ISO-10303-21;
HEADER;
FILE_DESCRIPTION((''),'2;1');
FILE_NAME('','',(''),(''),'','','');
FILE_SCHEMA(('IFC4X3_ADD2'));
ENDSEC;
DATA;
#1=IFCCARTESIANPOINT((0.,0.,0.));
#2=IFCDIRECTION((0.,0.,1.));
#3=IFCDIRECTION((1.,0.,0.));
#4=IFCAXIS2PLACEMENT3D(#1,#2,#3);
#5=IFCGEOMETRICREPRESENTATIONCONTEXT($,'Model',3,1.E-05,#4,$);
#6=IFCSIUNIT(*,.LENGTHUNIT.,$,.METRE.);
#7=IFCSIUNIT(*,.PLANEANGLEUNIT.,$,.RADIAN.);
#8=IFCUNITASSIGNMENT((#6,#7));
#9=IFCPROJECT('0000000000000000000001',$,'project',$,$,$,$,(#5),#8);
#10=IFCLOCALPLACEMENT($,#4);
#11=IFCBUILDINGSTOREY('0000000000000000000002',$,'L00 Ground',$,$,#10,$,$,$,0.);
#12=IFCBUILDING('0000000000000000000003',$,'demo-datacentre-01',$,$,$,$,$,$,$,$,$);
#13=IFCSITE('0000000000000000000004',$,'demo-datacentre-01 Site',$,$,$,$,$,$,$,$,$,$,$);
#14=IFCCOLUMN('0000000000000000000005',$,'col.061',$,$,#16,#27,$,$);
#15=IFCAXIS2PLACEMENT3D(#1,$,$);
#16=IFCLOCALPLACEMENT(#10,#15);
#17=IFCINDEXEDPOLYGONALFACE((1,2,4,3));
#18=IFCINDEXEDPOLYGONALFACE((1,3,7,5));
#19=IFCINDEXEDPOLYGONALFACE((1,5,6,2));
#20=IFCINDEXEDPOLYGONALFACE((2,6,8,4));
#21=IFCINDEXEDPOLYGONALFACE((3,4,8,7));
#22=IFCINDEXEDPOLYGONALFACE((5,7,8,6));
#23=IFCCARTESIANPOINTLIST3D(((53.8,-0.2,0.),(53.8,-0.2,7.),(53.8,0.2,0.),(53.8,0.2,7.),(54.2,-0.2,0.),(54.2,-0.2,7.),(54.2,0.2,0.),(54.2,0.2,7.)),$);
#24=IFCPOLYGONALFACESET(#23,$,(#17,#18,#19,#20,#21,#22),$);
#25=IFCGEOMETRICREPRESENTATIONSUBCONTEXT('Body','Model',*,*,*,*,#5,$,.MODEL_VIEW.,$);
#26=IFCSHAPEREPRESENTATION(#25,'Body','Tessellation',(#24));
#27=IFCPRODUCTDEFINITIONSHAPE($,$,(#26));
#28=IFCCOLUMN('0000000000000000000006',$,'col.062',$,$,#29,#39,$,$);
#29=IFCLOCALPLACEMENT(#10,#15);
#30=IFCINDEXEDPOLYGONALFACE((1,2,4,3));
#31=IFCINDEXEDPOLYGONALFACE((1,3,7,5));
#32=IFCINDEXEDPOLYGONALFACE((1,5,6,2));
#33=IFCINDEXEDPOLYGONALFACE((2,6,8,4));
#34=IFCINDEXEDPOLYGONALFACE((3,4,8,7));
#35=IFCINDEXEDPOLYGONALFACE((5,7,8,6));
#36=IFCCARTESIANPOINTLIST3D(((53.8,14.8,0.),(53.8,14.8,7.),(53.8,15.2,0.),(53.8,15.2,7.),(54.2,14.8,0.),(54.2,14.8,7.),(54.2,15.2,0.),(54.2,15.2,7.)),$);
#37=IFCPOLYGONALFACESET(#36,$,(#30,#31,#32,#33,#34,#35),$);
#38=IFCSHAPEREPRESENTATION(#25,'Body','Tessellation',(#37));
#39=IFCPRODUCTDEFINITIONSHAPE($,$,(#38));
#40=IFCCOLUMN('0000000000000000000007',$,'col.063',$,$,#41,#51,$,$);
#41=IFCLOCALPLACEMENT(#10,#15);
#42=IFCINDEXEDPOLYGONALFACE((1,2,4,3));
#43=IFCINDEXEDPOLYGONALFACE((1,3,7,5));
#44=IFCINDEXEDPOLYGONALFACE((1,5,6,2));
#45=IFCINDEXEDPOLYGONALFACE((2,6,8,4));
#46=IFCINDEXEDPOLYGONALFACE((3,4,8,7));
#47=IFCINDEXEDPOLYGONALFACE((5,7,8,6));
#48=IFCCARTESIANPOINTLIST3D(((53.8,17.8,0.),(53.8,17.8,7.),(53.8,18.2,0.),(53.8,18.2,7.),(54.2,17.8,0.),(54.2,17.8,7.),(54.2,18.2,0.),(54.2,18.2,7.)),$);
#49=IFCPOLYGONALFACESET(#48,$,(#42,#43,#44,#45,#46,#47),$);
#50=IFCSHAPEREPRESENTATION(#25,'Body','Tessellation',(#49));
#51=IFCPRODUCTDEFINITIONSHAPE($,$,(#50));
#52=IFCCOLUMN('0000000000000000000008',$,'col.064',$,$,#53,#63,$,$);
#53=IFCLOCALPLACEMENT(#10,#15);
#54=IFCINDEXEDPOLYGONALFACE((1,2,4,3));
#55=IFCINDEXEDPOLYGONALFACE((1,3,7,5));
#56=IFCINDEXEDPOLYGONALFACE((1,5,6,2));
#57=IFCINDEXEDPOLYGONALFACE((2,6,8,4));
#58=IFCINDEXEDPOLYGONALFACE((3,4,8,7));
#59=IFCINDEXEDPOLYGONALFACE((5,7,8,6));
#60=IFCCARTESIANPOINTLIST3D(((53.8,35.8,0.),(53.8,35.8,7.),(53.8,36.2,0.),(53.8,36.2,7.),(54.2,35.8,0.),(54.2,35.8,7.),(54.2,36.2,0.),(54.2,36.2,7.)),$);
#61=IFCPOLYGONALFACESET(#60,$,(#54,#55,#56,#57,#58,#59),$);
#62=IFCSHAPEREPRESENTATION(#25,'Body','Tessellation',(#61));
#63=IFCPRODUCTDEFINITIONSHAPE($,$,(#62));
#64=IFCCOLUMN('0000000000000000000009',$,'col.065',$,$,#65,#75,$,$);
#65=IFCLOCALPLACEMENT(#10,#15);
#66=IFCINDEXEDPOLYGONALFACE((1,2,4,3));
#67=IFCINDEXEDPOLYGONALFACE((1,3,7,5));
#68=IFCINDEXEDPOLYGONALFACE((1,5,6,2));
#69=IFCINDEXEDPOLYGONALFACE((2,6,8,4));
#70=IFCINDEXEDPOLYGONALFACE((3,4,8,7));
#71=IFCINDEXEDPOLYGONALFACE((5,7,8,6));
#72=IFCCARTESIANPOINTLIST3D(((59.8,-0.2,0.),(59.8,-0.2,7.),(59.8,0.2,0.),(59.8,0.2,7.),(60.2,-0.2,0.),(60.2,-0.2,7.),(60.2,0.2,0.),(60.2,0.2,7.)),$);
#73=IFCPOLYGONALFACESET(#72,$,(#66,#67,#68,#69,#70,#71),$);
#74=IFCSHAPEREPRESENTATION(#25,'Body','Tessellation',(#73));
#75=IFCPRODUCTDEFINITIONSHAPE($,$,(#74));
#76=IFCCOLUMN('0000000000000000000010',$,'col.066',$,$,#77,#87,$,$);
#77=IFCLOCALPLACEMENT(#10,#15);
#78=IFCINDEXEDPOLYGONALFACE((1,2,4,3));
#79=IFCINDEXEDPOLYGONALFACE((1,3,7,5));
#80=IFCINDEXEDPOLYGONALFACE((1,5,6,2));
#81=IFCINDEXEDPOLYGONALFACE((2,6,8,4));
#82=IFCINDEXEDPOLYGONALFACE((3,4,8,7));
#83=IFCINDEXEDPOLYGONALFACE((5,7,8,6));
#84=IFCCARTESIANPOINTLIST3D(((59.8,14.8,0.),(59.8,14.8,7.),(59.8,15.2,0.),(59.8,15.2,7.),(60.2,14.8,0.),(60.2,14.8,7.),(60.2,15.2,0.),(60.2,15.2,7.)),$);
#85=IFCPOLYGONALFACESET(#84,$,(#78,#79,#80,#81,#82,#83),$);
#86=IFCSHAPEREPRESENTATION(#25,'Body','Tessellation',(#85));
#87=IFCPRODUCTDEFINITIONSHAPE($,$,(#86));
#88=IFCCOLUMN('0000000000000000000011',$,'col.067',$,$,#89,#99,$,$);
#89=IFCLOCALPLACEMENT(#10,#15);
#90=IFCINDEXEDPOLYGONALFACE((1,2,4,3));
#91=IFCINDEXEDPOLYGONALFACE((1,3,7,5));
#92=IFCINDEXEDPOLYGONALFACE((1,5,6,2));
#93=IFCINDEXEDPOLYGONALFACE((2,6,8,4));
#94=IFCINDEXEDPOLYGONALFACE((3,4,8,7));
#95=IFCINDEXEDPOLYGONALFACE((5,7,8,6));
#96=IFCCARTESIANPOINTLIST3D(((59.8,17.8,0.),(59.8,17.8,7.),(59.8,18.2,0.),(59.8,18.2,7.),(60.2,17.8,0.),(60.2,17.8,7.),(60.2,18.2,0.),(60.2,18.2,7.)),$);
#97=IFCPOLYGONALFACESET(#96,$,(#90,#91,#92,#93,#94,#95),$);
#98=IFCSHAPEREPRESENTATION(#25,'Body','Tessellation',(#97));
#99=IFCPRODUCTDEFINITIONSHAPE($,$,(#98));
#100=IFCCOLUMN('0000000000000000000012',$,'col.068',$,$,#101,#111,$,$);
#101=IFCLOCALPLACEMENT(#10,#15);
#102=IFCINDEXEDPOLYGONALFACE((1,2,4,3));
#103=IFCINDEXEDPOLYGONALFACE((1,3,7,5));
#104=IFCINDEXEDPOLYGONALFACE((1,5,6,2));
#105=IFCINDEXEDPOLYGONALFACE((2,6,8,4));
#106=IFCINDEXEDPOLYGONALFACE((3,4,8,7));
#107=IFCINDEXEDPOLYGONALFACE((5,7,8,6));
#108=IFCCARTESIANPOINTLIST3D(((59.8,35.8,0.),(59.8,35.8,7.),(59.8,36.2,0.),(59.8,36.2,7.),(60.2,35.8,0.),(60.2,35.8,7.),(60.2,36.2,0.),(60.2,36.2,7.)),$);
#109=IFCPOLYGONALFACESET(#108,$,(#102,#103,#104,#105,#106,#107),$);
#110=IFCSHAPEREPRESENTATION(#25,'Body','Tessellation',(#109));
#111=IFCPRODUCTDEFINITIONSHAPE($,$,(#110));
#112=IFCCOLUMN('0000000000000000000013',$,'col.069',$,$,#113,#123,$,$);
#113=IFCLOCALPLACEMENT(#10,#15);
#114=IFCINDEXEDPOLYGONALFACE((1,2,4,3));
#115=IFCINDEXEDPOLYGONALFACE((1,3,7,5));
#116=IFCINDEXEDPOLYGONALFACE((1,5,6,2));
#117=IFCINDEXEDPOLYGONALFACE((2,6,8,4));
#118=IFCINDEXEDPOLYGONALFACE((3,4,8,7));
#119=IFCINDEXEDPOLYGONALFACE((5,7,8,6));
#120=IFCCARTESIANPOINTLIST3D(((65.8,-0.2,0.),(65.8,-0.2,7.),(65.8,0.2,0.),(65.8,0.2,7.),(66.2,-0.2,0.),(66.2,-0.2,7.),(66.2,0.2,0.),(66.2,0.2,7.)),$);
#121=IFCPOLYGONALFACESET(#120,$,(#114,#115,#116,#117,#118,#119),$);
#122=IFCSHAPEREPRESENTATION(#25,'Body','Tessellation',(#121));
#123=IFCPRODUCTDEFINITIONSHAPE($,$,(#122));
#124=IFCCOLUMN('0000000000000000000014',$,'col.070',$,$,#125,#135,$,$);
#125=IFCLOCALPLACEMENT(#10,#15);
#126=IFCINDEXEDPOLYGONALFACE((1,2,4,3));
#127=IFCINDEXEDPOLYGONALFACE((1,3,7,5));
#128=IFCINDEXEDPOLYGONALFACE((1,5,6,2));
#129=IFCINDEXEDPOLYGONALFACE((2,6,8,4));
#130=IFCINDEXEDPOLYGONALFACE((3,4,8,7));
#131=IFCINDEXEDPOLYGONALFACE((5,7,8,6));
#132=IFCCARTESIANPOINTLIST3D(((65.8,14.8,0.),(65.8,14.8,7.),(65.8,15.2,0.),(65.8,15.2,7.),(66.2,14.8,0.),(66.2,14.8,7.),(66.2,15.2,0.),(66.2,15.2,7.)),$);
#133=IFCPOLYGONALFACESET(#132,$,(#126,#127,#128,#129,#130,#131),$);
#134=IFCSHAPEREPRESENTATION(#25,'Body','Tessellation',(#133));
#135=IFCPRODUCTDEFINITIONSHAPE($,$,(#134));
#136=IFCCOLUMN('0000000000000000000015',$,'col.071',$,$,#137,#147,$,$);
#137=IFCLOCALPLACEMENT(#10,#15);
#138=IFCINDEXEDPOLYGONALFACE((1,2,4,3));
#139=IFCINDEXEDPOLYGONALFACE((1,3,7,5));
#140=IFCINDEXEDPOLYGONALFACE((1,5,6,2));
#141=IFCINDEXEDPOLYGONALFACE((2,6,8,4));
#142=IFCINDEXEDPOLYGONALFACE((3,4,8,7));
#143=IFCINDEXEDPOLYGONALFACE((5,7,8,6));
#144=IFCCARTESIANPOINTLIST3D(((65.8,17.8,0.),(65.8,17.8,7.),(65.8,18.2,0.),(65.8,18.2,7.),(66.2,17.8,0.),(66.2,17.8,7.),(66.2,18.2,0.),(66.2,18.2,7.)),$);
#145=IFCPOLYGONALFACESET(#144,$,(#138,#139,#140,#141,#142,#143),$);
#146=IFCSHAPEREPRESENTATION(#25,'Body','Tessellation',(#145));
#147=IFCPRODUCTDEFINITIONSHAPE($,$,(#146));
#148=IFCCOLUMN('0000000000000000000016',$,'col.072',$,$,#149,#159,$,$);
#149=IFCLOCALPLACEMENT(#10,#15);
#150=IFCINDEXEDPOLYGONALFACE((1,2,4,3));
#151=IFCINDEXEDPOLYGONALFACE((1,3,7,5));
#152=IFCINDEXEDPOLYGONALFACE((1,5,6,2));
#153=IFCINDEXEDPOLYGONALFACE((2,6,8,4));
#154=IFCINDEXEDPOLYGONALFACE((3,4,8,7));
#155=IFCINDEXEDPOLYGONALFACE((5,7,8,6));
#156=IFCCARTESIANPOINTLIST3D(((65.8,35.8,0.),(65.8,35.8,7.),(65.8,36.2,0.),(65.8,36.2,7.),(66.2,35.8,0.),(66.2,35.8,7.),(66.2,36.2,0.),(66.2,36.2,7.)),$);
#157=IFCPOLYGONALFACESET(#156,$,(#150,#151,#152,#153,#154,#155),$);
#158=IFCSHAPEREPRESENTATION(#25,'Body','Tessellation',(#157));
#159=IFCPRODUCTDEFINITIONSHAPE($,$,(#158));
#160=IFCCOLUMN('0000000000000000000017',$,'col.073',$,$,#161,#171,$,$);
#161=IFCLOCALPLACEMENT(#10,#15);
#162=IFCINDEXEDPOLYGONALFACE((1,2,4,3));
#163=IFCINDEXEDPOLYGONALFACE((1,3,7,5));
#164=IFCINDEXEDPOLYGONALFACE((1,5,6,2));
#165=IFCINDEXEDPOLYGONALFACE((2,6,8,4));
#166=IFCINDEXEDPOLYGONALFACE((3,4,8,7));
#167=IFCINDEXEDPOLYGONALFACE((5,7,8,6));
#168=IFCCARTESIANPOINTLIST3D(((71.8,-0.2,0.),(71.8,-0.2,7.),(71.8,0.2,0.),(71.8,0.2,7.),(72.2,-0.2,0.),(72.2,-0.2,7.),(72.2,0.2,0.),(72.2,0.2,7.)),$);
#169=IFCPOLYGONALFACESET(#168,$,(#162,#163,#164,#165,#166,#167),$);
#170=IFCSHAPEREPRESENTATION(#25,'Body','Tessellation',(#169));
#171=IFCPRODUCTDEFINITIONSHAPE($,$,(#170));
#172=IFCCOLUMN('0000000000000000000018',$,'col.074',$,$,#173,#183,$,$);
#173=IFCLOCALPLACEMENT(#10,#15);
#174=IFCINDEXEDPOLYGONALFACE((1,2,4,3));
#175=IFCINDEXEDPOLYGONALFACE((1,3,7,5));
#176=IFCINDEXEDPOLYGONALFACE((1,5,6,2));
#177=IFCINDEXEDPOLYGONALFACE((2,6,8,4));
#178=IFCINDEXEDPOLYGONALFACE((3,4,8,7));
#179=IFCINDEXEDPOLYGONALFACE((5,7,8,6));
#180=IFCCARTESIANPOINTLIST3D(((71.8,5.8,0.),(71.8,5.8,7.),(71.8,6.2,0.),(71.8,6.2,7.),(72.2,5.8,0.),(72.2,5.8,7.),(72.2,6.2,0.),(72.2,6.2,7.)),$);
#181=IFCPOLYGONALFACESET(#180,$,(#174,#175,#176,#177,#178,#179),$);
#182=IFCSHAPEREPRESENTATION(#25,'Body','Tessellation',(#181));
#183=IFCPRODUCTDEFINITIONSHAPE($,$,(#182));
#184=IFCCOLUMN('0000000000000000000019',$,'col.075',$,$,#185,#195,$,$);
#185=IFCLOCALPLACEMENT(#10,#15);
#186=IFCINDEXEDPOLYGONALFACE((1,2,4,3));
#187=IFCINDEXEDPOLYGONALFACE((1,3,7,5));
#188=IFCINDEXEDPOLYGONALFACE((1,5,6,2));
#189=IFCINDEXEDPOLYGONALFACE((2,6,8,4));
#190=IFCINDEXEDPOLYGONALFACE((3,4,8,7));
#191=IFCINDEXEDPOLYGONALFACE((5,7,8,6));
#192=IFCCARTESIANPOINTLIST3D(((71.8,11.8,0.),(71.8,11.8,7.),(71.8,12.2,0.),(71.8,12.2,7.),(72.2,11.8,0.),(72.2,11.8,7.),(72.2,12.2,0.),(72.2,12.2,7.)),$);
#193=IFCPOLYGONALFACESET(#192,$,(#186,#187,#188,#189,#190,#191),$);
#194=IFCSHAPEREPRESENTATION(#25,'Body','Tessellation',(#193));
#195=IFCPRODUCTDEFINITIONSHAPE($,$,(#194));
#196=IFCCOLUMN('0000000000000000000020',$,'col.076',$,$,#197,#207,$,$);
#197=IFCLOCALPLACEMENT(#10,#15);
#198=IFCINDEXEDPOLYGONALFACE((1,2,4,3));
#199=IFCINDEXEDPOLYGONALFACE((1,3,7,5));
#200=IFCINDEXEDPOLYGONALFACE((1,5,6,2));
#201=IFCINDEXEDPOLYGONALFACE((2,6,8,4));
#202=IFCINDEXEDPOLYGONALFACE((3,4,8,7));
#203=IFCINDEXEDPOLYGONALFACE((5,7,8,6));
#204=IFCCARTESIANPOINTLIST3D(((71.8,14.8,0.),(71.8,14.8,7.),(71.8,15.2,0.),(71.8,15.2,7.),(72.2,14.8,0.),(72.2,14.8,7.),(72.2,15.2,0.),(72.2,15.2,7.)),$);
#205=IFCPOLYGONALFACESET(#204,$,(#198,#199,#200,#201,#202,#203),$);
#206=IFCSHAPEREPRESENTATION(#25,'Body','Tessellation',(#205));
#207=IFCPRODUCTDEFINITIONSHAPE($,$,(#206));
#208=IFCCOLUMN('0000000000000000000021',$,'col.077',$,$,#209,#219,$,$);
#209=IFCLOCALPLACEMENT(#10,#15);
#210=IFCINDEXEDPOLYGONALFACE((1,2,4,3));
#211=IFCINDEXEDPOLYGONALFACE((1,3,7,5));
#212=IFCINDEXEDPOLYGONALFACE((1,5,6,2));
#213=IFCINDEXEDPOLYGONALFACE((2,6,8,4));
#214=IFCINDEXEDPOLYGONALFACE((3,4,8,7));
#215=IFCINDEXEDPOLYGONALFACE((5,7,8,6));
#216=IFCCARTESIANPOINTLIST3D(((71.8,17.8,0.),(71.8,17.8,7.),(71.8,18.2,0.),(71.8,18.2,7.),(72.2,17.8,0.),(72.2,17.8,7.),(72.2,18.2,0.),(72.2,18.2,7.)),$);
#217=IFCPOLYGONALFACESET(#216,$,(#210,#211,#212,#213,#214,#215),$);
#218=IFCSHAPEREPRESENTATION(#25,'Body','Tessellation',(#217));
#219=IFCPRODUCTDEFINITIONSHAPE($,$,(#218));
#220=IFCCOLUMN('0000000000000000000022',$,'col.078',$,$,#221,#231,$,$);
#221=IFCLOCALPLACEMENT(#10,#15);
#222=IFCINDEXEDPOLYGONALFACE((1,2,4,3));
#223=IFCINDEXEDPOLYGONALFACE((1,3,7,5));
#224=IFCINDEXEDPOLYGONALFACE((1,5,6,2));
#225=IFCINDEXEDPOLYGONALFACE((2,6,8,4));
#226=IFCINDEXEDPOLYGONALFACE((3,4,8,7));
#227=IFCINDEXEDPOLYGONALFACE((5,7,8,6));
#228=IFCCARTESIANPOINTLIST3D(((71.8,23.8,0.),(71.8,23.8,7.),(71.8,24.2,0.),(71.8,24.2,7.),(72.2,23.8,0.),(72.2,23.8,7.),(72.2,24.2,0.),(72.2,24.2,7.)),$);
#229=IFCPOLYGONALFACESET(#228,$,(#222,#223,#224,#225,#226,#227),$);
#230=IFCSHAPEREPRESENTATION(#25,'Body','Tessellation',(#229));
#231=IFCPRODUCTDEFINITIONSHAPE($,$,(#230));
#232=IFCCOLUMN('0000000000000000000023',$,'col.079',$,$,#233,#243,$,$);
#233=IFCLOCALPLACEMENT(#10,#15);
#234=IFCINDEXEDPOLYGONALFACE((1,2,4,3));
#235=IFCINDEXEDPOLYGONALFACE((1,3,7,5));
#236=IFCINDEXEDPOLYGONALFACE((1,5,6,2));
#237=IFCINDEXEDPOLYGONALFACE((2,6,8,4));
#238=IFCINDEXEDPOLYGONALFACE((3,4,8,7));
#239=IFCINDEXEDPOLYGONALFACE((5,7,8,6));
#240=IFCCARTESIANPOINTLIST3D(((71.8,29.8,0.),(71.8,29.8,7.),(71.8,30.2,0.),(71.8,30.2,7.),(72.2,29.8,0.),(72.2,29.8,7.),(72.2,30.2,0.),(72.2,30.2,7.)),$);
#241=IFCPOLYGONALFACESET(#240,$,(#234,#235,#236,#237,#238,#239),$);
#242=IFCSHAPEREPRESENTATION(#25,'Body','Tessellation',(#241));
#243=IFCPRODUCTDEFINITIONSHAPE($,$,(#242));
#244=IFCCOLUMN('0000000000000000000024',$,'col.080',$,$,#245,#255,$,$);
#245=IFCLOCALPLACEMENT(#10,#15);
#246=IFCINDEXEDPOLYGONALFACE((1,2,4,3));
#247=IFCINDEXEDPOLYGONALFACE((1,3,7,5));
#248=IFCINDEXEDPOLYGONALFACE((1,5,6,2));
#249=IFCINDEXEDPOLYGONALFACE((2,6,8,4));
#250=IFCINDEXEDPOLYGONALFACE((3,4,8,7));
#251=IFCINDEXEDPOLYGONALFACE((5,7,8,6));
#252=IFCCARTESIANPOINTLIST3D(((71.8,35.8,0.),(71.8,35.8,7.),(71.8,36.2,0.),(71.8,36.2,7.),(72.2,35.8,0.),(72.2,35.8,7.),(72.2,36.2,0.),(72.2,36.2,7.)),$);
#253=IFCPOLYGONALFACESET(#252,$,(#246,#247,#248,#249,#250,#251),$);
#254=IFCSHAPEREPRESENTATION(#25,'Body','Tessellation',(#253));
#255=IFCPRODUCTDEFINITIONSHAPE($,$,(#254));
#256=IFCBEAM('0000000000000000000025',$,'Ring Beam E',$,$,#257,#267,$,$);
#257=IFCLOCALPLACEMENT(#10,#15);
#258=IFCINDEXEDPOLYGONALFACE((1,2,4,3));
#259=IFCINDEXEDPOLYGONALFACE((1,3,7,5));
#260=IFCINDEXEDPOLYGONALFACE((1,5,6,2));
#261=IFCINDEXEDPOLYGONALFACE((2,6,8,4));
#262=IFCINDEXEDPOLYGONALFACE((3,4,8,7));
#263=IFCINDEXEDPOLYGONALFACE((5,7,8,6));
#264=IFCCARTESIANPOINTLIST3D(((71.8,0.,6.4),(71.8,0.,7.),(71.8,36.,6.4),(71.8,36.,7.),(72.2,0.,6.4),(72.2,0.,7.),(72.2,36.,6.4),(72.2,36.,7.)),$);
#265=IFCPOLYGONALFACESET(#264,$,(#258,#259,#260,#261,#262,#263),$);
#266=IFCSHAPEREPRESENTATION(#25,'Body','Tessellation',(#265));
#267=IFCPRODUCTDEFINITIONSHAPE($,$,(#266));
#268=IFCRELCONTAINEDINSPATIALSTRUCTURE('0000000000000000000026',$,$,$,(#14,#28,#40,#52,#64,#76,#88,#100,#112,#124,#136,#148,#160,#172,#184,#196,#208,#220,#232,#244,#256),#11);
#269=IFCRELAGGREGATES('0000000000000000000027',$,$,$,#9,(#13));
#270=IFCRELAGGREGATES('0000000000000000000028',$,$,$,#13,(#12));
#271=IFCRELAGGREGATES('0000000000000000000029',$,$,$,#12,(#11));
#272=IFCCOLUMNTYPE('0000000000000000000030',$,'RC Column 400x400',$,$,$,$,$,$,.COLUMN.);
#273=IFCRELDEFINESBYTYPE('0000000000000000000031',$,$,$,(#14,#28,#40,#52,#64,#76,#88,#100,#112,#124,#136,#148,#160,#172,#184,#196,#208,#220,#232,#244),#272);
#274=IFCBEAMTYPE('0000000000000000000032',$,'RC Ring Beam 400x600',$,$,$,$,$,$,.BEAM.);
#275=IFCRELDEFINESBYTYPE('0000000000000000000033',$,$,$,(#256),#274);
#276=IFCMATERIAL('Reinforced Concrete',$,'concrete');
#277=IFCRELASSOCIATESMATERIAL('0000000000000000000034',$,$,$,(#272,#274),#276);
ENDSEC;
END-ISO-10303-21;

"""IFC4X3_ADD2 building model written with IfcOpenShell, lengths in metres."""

from ifc_helpers import new_model, si_unit, frame, origin_with_axes, place, context, subcontext, project, spatial, rectangle, extrude, material, type_object, element, save


model = new_model("IFC4X3_ADD2")

# Units and contexts
model_context = context("Model", 3, precision=1e-05, world=origin_with_axes())
body_context = subcontext(model_context, "Body", "Model", "MODEL_VIEW")
ifc_project = project(units=[si_unit("LENGTHUNIT", "METRE"), si_unit("PLANEANGLEUNIT", "RADIAN")], contexts=[model_context])

# Site, building, storey
site = spatial("IfcSite", under=ifc_project, Name="demo-datacentre-01 Site")
building = spatial("IfcBuilding", under=site, Name="demo-datacentre-01")
storey_placement = place(None, origin_with_axes())
storey = spatial("IfcBuildingStorey", under=building, at=storey_placement, Name="L00 Ground", Elevation=0.0)

# Columns
ifc_material = material(Name="Reinforced Concrete", Category="concrete")
column_type = type_object("IfcColumnType", Name="RC Column 400x400", PredefinedType="COLUMN", material=ifc_material)
for number, where, z_axis, x_axis, name in (
    (1, (54.0, 0.0, 0.0), (0.0, 0.0, 1.0), (1.0, 0.0, 0.0), "col.061"),
    (2, (54.0, 15.0, 0.0), (0.0, 0.0, 1.0), (1.0, 0.0, 0.0), "col.062"),
    (3, (54.0, 18.0, 0.0), (0.0, 0.0, 1.0), (1.0, 0.0, 0.0), "col.063"),
    (4, (54.0, 36.0, 0.0), (0.0, 0.0, 1.0), (1.0, 0.0, 0.0), "col.064"),
    (5, (60.0, 0.0, 0.0), (0.0, 0.0, 1.0), (1.0, 0.0, 0.0), "col.065"),
    (6, (60.0, 15.0, 0.0), (0.0, 0.0, 1.0), (1.0, 0.0, 0.0), "col.066"),
    (7, (60.0, 18.0, 0.0), (0.0, 0.0, 1.0), (1.0, 0.0, 0.0), "col.067"),
    (8, (60.0, 36.0, 0.0), (0.0, 0.0, 1.0), (1.0, 0.0, 0.0), "col.068"),
    (9, (66.0, 0.0, 0.0), (0.0, 0.0, 1.0), (1.0, 0.0, 0.0), "col.069"),
    (10, (66.0, 15.0, 0.0), (0.0, 0.0, 1.0), (1.0, 0.0, 0.0), "col.070"),
    (11, (66.0, 18.0, 0.0), (0.0, 0.0, 1.0), (1.0, 0.0, 0.0), "col.071"),
    (12, (66.0, 36.0, 0.0), (0.0, 0.0, 1.0), (1.0, 0.0, 0.0), "col.072"),
    (13, (72.0, 0.0, 0.0), (0.0, 0.0, 1.0), (1.0, 0.0, 0.0), "col.073"),
    (14, (72.0, 6.0, 0.0), (0.0, 0.0, 1.0), (1.0, 0.0, 0.0), "col.074"),
    (15, (72.0, 12.0, 0.0), (0.0, 0.0, 1.0), (1.0, 0.0, 0.0), "col.075"),
    (16, (72.0, 15.0, 0.0), (0.0, 0.0, 1.0), (1.0, 0.0, 0.0), "col.076"),
    (17, (72.0, 18.0, 0.0), (0.0, 0.0, 1.0), (1.0, 0.0, 0.0), "col.077"),
    (18, (72.0, 24.0, 0.0), (0.0, 0.0, 1.0), (1.0, 0.0, 0.0), "col.078"),
    (19, (72.0, 30.0, 0.0), (0.0, 0.0, 1.0), (1.0, 0.0, 0.0), "col.079"),
    (20, (72.0, 36.0, 0.0), (0.0, 0.0, 1.0), (1.0, 0.0, 0.0), "col.080"),
):
    element("IfcColumn", number, at=place(storey_placement, frame(where, z_axis=z_axis, x_axis=x_axis)), inside=storey, type_object=column_type, Name=name, context=body_context, shape_type="SweptSolid", body=[
        extrude(rectangle(XDim=0.4, YDim=0.4), origin_with_axes(), (0.0, 0.0, 1.0), 7.0),
    ])

# Beam
beam_type = type_object("IfcBeamType", Name="RC Ring Beam 400x600", PredefinedType="BEAM", material=ifc_material)
beam_placement = place(storey_placement, frame((72.0, 0.0, 6.7), z_axis=(0.0, 1.0, 0.0), x_axis=(-1.0, 0.0, 0.0)))
element("IfcBeam", 21, at=beam_placement, inside=storey, type_object=beam_type, Name="Ring Beam E", context=body_context, shape_type="SweptSolid", body=[
    extrude(rectangle(XDim=0.4, YDim=0.6), origin_with_axes(), (0.0, 0.0, 1.0), 36.0),
])

save(model, "model.ifc")
